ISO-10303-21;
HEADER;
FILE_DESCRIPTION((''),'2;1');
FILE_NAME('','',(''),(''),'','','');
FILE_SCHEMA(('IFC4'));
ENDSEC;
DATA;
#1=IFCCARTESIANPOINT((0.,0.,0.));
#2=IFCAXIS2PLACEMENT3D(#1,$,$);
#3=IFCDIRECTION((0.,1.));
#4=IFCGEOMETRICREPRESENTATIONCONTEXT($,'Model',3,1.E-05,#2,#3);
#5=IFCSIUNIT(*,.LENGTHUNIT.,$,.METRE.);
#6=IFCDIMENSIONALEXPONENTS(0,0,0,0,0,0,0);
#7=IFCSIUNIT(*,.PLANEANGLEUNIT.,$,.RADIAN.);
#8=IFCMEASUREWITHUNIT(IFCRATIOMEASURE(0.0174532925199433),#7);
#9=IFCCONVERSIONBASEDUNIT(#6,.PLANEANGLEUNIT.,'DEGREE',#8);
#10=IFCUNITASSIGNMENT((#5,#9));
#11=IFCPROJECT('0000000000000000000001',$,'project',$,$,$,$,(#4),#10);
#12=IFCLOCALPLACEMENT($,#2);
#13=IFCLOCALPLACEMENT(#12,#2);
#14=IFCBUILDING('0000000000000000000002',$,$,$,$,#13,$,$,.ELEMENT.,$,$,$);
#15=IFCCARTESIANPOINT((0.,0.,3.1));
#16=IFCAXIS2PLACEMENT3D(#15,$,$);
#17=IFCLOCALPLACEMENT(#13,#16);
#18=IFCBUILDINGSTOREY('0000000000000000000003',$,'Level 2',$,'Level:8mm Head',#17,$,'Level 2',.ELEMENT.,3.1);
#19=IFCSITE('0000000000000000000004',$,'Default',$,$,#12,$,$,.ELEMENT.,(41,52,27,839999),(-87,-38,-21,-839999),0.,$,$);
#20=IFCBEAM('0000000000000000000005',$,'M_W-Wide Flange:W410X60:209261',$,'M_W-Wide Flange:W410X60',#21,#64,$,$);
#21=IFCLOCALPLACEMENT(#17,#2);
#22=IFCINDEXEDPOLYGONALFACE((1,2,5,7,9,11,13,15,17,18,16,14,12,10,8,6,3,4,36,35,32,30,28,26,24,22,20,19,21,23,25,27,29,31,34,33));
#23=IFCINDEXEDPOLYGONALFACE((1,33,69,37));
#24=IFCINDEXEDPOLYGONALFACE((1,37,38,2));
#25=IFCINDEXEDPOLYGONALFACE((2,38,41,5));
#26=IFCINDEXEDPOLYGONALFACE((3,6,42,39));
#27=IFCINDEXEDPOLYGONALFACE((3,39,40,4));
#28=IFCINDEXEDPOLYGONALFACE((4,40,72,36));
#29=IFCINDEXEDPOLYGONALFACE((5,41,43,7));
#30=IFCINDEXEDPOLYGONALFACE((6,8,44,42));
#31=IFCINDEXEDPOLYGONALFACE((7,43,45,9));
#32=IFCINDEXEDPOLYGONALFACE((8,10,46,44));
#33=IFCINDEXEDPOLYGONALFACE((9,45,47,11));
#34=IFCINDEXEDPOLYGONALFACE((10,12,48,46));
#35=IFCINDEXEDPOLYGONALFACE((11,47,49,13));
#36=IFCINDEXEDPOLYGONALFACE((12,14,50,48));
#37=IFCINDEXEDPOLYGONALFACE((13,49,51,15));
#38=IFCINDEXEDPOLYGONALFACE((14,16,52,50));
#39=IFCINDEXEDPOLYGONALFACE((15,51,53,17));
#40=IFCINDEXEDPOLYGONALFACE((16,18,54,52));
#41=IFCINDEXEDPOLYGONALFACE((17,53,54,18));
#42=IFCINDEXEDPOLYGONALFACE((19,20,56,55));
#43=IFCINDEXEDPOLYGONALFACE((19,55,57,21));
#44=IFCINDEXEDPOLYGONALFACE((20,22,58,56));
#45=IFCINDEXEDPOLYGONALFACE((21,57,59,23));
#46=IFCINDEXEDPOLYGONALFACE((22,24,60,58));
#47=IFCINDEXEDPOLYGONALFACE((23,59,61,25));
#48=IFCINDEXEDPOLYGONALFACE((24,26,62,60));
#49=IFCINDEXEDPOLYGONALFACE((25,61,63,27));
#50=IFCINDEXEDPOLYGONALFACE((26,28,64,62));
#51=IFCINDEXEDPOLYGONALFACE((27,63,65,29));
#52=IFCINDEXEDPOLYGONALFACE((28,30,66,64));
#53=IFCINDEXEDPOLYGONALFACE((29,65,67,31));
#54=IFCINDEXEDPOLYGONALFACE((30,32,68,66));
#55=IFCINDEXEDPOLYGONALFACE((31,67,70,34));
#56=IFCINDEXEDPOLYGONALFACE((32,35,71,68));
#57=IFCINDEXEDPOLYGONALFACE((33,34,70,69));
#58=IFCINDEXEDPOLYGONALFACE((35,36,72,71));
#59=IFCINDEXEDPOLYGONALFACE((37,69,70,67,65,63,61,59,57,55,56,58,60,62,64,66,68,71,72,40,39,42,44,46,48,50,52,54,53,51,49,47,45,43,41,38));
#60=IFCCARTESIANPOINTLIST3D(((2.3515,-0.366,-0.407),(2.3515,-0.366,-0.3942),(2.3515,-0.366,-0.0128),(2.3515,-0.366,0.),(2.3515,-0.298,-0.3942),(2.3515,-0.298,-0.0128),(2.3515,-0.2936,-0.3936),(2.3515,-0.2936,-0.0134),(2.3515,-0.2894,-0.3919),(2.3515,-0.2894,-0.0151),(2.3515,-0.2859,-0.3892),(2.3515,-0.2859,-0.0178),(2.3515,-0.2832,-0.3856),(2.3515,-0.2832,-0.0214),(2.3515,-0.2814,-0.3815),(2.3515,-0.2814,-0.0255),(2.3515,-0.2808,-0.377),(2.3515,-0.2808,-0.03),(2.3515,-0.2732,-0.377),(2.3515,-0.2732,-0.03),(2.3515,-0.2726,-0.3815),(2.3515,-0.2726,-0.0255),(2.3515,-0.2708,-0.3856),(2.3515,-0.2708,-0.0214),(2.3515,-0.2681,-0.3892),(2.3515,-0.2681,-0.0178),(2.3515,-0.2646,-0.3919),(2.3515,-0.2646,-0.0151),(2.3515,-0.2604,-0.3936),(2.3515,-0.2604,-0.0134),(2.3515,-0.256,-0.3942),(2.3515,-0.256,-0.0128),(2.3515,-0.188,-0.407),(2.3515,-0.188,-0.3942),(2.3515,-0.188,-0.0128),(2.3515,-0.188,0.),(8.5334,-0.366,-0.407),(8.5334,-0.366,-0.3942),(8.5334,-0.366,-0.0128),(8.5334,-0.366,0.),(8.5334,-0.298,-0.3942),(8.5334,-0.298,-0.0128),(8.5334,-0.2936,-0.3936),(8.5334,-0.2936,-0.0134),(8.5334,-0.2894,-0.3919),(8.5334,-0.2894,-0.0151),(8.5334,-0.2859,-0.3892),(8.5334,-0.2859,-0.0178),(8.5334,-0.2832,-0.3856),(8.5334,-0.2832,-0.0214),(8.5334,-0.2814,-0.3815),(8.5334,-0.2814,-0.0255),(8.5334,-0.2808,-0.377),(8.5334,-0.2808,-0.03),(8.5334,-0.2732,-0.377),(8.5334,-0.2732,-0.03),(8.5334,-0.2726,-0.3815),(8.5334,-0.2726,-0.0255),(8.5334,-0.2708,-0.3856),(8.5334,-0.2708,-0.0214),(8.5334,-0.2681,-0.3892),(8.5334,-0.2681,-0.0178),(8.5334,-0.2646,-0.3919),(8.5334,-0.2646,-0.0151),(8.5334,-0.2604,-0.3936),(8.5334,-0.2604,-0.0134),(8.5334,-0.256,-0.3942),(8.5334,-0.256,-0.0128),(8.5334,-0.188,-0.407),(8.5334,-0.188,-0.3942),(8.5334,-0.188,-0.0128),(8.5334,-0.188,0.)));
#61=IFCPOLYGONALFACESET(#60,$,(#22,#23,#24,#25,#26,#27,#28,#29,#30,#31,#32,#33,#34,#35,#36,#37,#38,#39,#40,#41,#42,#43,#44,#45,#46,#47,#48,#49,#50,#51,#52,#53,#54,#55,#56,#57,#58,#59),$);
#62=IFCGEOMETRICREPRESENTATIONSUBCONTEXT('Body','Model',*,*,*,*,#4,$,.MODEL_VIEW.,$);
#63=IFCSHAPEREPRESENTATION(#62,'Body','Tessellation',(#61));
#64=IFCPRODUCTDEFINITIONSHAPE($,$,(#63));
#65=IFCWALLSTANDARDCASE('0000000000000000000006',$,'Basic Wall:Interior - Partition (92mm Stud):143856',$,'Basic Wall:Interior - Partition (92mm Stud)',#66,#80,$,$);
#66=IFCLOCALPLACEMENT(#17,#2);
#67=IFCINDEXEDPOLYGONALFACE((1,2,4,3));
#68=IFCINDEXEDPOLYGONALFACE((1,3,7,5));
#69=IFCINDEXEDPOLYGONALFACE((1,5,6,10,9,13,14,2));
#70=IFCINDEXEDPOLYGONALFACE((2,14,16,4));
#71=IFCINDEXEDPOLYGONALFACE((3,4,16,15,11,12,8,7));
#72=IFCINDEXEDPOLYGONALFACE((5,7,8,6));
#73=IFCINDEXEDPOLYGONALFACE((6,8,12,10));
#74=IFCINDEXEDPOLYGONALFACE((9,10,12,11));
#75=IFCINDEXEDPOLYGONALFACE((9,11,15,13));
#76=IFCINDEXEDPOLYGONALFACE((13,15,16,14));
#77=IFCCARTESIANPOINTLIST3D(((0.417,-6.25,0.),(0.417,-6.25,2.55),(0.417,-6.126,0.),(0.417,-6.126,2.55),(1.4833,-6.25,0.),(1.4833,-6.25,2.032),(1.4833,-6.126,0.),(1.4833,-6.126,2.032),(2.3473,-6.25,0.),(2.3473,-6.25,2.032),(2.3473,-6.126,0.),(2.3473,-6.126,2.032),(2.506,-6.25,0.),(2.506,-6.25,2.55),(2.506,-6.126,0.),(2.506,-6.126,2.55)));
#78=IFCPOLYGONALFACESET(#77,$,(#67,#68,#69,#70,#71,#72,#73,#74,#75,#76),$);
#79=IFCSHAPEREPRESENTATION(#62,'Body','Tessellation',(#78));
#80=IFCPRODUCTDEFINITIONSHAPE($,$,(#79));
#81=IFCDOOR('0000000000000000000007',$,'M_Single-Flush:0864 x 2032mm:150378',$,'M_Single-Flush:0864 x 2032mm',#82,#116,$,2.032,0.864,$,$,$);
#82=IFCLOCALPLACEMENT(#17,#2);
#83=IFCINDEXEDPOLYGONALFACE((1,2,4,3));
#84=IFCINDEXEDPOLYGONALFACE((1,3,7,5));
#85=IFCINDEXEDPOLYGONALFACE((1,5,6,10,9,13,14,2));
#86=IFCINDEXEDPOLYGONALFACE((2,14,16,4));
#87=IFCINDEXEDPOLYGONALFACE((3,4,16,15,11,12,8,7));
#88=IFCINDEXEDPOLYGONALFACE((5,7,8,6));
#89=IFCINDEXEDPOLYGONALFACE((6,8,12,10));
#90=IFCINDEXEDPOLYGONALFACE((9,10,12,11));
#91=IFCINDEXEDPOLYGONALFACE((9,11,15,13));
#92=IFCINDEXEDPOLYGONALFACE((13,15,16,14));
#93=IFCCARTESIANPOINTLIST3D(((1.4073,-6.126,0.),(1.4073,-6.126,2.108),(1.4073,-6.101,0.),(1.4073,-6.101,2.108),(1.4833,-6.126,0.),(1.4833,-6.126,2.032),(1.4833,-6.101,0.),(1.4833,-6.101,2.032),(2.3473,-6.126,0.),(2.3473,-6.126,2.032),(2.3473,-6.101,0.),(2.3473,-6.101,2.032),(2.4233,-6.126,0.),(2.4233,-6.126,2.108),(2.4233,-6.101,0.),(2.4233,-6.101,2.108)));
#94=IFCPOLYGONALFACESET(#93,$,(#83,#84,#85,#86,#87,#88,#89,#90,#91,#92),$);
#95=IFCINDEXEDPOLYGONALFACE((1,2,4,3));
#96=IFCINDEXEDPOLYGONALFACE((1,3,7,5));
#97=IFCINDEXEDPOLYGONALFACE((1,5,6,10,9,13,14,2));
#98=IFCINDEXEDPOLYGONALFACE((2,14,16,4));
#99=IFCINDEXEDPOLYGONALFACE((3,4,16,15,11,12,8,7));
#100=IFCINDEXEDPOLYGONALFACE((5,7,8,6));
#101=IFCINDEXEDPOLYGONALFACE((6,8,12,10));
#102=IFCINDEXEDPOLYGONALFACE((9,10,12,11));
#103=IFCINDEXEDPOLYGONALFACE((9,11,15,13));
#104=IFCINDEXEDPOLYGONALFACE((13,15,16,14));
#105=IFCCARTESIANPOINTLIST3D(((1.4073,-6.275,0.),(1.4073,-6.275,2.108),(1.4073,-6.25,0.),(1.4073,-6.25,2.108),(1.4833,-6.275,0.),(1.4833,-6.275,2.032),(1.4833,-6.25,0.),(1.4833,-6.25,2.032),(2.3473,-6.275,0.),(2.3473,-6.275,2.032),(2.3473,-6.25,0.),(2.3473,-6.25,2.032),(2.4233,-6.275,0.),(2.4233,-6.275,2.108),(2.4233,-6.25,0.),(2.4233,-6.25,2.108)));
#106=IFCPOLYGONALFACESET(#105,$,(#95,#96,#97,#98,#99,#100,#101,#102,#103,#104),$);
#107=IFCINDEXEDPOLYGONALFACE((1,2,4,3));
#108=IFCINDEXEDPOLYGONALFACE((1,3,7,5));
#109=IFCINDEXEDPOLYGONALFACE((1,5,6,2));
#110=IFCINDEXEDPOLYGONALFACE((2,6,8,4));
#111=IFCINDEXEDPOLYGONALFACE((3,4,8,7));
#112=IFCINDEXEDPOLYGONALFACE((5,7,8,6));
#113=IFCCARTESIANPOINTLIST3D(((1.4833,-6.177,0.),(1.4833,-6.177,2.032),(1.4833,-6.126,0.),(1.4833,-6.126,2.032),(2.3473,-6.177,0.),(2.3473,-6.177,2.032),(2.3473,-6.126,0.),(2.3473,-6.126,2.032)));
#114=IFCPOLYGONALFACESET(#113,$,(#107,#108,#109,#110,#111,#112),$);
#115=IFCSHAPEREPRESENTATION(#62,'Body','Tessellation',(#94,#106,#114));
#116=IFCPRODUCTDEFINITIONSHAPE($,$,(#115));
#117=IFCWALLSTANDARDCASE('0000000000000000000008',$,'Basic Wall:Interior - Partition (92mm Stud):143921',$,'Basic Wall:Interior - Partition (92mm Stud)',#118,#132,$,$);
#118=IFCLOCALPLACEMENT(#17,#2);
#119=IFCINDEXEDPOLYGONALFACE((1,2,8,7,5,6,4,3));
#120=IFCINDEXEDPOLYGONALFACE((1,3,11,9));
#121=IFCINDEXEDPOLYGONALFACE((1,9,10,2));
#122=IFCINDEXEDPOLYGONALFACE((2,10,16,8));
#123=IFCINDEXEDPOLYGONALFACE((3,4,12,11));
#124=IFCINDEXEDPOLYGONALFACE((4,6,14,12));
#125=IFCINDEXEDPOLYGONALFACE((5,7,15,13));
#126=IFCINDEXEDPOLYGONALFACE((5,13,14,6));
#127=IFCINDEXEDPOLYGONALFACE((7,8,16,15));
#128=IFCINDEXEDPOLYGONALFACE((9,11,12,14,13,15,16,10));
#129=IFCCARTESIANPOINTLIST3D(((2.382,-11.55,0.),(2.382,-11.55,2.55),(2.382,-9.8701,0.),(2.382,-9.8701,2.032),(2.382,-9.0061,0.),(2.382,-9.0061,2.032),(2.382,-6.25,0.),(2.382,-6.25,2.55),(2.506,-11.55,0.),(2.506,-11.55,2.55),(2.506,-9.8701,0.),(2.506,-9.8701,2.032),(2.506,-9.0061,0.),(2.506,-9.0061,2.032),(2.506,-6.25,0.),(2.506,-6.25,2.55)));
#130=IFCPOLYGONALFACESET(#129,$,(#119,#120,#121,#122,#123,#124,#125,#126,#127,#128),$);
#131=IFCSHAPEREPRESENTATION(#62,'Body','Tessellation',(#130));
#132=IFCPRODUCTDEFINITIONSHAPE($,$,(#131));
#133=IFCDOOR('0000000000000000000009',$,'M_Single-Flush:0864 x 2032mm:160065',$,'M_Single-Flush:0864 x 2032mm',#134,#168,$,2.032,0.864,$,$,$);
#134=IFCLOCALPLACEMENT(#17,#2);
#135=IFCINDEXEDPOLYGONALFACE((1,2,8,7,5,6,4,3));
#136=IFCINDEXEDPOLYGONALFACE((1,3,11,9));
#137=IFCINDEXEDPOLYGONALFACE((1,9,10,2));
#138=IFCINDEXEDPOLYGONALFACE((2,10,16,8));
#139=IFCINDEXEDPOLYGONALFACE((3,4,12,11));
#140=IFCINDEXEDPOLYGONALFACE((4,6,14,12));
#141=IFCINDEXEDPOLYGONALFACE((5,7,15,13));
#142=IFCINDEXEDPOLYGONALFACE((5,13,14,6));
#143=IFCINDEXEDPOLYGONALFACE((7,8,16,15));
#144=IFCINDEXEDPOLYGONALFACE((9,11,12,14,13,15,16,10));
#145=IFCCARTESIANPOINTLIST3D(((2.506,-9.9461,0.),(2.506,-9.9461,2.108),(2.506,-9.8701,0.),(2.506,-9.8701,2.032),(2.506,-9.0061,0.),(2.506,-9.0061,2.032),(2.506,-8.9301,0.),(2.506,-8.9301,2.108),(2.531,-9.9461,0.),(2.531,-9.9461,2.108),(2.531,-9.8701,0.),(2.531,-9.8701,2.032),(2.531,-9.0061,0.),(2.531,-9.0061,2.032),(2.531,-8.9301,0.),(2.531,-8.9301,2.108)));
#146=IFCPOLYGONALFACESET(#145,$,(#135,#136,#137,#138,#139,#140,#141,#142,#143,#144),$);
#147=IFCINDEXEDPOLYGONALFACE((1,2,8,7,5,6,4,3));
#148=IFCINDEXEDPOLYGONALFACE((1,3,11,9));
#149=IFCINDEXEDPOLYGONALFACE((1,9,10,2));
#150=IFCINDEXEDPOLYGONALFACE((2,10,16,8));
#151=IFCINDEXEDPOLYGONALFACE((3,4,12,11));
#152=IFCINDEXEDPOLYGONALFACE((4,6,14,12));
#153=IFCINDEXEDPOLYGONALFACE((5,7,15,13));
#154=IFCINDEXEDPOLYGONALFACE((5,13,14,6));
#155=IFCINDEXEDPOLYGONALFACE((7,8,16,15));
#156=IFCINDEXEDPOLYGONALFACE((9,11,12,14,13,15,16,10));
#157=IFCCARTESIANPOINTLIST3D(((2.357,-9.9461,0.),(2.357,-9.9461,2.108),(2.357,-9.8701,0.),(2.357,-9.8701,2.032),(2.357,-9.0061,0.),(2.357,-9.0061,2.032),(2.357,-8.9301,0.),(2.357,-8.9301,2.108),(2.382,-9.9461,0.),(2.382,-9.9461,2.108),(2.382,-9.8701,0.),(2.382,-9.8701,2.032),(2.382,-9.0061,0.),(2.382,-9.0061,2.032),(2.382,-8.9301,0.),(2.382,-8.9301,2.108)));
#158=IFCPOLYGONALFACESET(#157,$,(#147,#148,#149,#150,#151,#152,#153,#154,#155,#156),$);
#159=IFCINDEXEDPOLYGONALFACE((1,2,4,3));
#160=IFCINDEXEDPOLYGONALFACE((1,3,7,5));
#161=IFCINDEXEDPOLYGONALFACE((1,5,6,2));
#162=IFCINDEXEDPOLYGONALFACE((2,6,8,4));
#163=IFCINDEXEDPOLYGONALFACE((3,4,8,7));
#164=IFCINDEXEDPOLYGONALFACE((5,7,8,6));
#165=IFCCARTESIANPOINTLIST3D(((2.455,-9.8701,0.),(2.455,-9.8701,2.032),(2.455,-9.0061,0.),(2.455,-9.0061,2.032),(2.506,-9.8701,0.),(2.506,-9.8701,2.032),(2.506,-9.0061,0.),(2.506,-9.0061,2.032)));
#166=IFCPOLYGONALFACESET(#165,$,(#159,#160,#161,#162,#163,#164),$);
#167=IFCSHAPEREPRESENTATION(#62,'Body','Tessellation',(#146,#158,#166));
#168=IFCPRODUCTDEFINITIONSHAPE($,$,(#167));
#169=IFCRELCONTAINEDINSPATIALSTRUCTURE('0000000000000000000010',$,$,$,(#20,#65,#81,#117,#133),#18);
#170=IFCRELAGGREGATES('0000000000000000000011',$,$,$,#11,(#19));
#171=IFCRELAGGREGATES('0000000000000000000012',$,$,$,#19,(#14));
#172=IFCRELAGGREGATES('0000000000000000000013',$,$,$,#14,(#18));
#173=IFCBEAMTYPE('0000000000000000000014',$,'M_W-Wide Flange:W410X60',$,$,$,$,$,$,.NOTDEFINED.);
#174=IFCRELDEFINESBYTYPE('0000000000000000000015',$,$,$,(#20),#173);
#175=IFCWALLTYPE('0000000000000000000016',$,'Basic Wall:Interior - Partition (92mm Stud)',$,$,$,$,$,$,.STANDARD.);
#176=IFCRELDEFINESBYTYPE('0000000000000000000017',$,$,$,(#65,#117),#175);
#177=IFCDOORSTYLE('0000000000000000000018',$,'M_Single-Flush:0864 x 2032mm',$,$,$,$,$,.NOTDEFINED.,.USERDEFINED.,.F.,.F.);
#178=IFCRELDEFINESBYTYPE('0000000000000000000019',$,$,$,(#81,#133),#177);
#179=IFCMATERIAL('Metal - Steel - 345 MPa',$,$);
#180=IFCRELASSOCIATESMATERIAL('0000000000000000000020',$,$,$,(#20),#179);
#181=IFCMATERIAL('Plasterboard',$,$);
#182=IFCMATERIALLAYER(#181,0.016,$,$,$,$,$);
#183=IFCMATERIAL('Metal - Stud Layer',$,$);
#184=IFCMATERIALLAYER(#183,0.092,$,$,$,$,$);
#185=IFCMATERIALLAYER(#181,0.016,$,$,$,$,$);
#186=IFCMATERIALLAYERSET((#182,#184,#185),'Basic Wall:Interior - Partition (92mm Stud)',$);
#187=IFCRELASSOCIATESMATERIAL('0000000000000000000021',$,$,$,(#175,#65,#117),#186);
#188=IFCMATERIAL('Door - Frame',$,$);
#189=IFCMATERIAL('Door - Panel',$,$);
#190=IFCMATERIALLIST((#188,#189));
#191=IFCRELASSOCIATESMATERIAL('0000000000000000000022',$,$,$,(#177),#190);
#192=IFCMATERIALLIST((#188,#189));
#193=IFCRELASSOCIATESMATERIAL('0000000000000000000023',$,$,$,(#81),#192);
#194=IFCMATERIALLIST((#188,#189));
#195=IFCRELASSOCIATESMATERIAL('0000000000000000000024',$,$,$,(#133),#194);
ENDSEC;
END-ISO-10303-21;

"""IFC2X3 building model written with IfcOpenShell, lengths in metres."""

from ifc_helpers import new_model, entity, si_unit, converted_unit, direction, frame, frame_2d, origin, origin_2d_with_axis, place, context, subcontext, project, spatial, polyline, rectangle, i_section, outline, extrude, source, transform, mapped, material, material_list, layer, layer_set, layer_usage, type_object, type_shapes, element, fill, save


model = new_model("IFC2X3")

# Units and contexts
model_context = context("Model", 3, precision=1e-05, world=origin(), true_north=direction((0.0, 1.0)))
body_context = subcontext(model_context, "Body", "Model", "MODEL_VIEW")
ifc_project = project(units=[si_unit("LENGTHUNIT", "METRE"), converted_unit("PLANEANGLEUNIT", "DEGREE", entity("IfcRatioMeasure", 0.0174532925199433), si_unit("PLANEANGLEUNIT", "RADIAN"), dimensions=[0, 0, 0, 0, 0, 0, 0])], contexts=[model_context])

# Site, building, storey
site_placement = place(None, origin())
site = spatial("IfcSite", under=ifc_project, at=site_placement, Name="Default", CompositionType="ELEMENT", RefLatitude=(41, 52, 27, 839999), RefLongitude=(-87, -38, -21, -839999), RefElevation=0.0)
building_placement = place(site_placement, origin())
building = spatial("IfcBuilding", under=site, at=building_placement, CompositionType="ELEMENT")
storey_placement = place(building_placement, frame((0.0, 0.0, 3.1)))
storey = spatial("IfcBuildingStorey", under=building, at=storey_placement, Name="Level 2", ObjectType="Level:8mm Head", LongName="Level 2", CompositionType="ELEMENT", Elevation=3.1)

# Beam
ifc_material_1 = material(Name="Metal - Steel - 345 MPa")
beam_type = type_object("IfcBeamType", Name="M_W-Wide Flange:W410X60", PredefinedType="NOTDEFINED")
beam_placement = place(storey_placement, frame((8.5334, -0.277, 0.0), z_axis=(0.0, 0.0, 1.0), x_axis=(-1.0, 0.0, 0.0)))
element("IfcBeam", 1, at=beam_placement, inside=storey, type_object=beam_type, material=ifc_material_1, Name="M_W-Wide Flange:W410X60:209261", ObjectType="M_W-Wide Flange:W410X60", context=body_context, shape_type="SweptSolid", body=[
    extrude(i_section(OverallWidth=0.178, OverallDepth=0.407, WebThickness=0.0077, FlangeThickness=0.0128, FilletRadius=0.0172, at=frame_2d((0.0, 0.0), x_axis=(0.0, 1.0))), frame((0.0, 0.0, -0.2035), z_axis=(1.0, 0.0, 0.0), x_axis=(0.0, 0.0, -1.0)), (0.0, 0.0, 1.0), 6.1819),
])

# Shared definitions
ifc_material_2 = material(Name="Metal - Stud Layer")
ifc_material_3 = material(Name="Plasterboard")

# Walls, openings, doors
ifc_layer_1 = layer(ifc_material_3, 0.016)
ifc_layer_2 = layer(ifc_material_2, 0.092)
ifc_layer_3 = layer(ifc_material_3, 0.016)
ifc_layer_set_1 = layer_set([ifc_layer_1, ifc_layer_2, ifc_layer_3], Name="Basic Wall:Interior - Partition (92mm Stud)")
ifc_layer_usage_1 = layer_usage(ifc_layer_set_1, "AXIS2", "NEGATIVE", 0.062)
wall_type_1 = type_object("IfcWallType", Name="Basic Wall:Interior - Partition (92mm Stud)", PredefinedType="STANDARD", material=ifc_layer_set_1)
wall_1_placement = place(storey_placement, frame((0.417, -6.188, 0.0)))
wall_1 = element("IfcWallStandardCase", 2, at=wall_1_placement, inside=storey, type_object=wall_type_1, material=ifc_layer_usage_1, Name="Basic Wall:Interior - Partition (92mm Stud):143856", ObjectType="Basic Wall:Interior - Partition (92mm Stud)", context=body_context, shape_type="SweptSolid", body=[
    extrude(rectangle(XDim=2.089, YDim=0.124, at=frame_2d((1.0445, 0.0), x_axis=(-1.0, 0.0))), origin(), (0.0, 0.0, 1.0), 2.55),
])
opening_1_placement = place(wall_1_placement, frame((1.0663, -0.062, 0.0)))
opening_1 = element("IfcOpeningElement", 3, at=opening_1_placement, cuts=wall_1, ObjectType="Opening", context=body_context, shape_type="SweptSolid", body=[
    extrude(rectangle(XDim=0.864, YDim=2.032, at=frame_2d((1.016, 0.432), x_axis=(0.0, 1.0))), frame((0.0, 0.0, 0.0), z_axis=(0.0, 1.0, 0.0), x_axis=(0.0, 0.0, 1.0)), (0.0, 0.0, 1.0), 0.124),
])
ifc_material_4 = material(Name="Door - Frame")
ifc_material_5 = material(Name="Door - Panel")
ifc_material_list_1 = material_list([ifc_material_4, ifc_material_5])
ifc_material_list_2 = material_list([ifc_material_4, ifc_material_5])
door_style_1 = type_object("IfcDoorStyle", Name="M_Single-Flush:0864 x 2032mm", ConstructionType="USERDEFINED", OperationType="NOTDEFINED", ParameterTakesPrecedence=False, Sizeable=False, material=ifc_material_list_2)
shared_shape_1 = source(origin(), body_context, "Body", "SweptSolid", [
    extrude(outline(polyline([(-0.508, -1.073), (0.508, -1.073), (0.508, 1.035), (0.432, 1.035), (0.432, -0.997), (-0.432, -0.997), (-0.432, 1.035), (-0.508, 1.035), (-0.508, -1.073)])), frame((0.432, 0.124, 1.035), z_axis=(0.0, 1.0, 0.0), x_axis=(1.0, 0.0, 0.0)), (0.0, 0.0, 1.0), 0.025),
    extrude(outline(polyline([(-1.073, -0.508), (1.035, -0.508), (1.035, -0.432), (-0.997, -0.432), (-0.997, 0.432), (1.035, 0.432), (1.035, 0.508), (-1.073, 0.508), (-1.073, -0.508)])), frame((0.432, -0.025, 1.035), z_axis=(0.0, 1.0, 0.0), x_axis=(0.0, 0.0, -1.0)), (0.0, 0.0, 1.0), 0.025),
    extrude(rectangle(XDim=0.051, YDim=0.864, at=origin_2d_with_axis()), frame((0.432, 0.0985, 0.0), z_axis=(0.0, 0.0, 1.0), x_axis=(0.0, 1.0, 0.0)), (0.0, 0.0, 1.0), 2.032),
])
type_shapes(door_style_1, [shared_shape_1])
door_1_placement = place(opening_1_placement, origin())
door_1 = element("IfcDoor", 4, at=door_1_placement, inside=storey, type_object=door_style_1, material=ifc_material_list_1, Name="M_Single-Flush:0864 x 2032mm:150378", ObjectType="M_Single-Flush:0864 x 2032mm", OverallHeight=2.032, OverallWidth=0.864, context=body_context, shape_type="MappedRepresentation", body=[
    mapped(shared_shape_1, transform((0.0, 0.0, 0.0), scale=1.0)),
])
fill(opening_1, door_1)
ifc_layer_usage_2 = layer_usage(ifc_layer_set_1, "AXIS2", "NEGATIVE", 0.062)
wall_2_placement = place(storey_placement, frame((2.444, -6.25, 0.0), z_axis=(0.0, 0.0, 1.0), x_axis=(0.0, -1.0, 0.0)))
wall_2 = element("IfcWallStandardCase", 5, at=wall_2_placement, inside=storey, type_object=wall_type_1, material=ifc_layer_usage_2, Name="Basic Wall:Interior - Partition (92mm Stud):143921", ObjectType="Basic Wall:Interior - Partition (92mm Stud)", context=body_context, shape_type="SweptSolid", body=[
    extrude(rectangle(XDim=5.3, YDim=0.124, at=frame_2d((2.65, 0.0), x_axis=(-1.0, 0.0))), origin(), (0.0, 0.0, 1.0), 2.55),
])
opening_2_placement = place(wall_2_placement, frame((2.7561, -0.062, 0.0)))
opening_2 = element("IfcOpeningElement", 6, at=opening_2_placement, cuts=wall_2, ObjectType="Opening", context=body_context, shape_type="SweptSolid", body=[
    extrude(rectangle(XDim=0.864, YDim=2.032, at=frame_2d((1.016, 0.432), x_axis=(0.0, 1.0))), frame((0.0, 0.0, 0.0), z_axis=(0.0, 1.0, 0.0), x_axis=(0.0, 0.0, 1.0)), (0.0, 0.0, 1.0), 0.124),
])
ifc_material_list_3 = material_list([ifc_material_4, ifc_material_5])
door_2_placement = place(opening_2_placement, origin())
door_2 = element("IfcDoor", 7, at=door_2_placement, inside=storey, type_object=door_style_1, material=ifc_material_list_3, Name="M_Single-Flush:0864 x 2032mm:160065", ObjectType="M_Single-Flush:0864 x 2032mm", OverallHeight=2.032, OverallWidth=0.864, context=body_context, shape_type="MappedRepresentation", body=[
    mapped(shared_shape_1, transform((0.0, 0.0, 0.0), scale=1.0)),
])
fill(opening_2, door_2)

save(model, "model.ifc")
